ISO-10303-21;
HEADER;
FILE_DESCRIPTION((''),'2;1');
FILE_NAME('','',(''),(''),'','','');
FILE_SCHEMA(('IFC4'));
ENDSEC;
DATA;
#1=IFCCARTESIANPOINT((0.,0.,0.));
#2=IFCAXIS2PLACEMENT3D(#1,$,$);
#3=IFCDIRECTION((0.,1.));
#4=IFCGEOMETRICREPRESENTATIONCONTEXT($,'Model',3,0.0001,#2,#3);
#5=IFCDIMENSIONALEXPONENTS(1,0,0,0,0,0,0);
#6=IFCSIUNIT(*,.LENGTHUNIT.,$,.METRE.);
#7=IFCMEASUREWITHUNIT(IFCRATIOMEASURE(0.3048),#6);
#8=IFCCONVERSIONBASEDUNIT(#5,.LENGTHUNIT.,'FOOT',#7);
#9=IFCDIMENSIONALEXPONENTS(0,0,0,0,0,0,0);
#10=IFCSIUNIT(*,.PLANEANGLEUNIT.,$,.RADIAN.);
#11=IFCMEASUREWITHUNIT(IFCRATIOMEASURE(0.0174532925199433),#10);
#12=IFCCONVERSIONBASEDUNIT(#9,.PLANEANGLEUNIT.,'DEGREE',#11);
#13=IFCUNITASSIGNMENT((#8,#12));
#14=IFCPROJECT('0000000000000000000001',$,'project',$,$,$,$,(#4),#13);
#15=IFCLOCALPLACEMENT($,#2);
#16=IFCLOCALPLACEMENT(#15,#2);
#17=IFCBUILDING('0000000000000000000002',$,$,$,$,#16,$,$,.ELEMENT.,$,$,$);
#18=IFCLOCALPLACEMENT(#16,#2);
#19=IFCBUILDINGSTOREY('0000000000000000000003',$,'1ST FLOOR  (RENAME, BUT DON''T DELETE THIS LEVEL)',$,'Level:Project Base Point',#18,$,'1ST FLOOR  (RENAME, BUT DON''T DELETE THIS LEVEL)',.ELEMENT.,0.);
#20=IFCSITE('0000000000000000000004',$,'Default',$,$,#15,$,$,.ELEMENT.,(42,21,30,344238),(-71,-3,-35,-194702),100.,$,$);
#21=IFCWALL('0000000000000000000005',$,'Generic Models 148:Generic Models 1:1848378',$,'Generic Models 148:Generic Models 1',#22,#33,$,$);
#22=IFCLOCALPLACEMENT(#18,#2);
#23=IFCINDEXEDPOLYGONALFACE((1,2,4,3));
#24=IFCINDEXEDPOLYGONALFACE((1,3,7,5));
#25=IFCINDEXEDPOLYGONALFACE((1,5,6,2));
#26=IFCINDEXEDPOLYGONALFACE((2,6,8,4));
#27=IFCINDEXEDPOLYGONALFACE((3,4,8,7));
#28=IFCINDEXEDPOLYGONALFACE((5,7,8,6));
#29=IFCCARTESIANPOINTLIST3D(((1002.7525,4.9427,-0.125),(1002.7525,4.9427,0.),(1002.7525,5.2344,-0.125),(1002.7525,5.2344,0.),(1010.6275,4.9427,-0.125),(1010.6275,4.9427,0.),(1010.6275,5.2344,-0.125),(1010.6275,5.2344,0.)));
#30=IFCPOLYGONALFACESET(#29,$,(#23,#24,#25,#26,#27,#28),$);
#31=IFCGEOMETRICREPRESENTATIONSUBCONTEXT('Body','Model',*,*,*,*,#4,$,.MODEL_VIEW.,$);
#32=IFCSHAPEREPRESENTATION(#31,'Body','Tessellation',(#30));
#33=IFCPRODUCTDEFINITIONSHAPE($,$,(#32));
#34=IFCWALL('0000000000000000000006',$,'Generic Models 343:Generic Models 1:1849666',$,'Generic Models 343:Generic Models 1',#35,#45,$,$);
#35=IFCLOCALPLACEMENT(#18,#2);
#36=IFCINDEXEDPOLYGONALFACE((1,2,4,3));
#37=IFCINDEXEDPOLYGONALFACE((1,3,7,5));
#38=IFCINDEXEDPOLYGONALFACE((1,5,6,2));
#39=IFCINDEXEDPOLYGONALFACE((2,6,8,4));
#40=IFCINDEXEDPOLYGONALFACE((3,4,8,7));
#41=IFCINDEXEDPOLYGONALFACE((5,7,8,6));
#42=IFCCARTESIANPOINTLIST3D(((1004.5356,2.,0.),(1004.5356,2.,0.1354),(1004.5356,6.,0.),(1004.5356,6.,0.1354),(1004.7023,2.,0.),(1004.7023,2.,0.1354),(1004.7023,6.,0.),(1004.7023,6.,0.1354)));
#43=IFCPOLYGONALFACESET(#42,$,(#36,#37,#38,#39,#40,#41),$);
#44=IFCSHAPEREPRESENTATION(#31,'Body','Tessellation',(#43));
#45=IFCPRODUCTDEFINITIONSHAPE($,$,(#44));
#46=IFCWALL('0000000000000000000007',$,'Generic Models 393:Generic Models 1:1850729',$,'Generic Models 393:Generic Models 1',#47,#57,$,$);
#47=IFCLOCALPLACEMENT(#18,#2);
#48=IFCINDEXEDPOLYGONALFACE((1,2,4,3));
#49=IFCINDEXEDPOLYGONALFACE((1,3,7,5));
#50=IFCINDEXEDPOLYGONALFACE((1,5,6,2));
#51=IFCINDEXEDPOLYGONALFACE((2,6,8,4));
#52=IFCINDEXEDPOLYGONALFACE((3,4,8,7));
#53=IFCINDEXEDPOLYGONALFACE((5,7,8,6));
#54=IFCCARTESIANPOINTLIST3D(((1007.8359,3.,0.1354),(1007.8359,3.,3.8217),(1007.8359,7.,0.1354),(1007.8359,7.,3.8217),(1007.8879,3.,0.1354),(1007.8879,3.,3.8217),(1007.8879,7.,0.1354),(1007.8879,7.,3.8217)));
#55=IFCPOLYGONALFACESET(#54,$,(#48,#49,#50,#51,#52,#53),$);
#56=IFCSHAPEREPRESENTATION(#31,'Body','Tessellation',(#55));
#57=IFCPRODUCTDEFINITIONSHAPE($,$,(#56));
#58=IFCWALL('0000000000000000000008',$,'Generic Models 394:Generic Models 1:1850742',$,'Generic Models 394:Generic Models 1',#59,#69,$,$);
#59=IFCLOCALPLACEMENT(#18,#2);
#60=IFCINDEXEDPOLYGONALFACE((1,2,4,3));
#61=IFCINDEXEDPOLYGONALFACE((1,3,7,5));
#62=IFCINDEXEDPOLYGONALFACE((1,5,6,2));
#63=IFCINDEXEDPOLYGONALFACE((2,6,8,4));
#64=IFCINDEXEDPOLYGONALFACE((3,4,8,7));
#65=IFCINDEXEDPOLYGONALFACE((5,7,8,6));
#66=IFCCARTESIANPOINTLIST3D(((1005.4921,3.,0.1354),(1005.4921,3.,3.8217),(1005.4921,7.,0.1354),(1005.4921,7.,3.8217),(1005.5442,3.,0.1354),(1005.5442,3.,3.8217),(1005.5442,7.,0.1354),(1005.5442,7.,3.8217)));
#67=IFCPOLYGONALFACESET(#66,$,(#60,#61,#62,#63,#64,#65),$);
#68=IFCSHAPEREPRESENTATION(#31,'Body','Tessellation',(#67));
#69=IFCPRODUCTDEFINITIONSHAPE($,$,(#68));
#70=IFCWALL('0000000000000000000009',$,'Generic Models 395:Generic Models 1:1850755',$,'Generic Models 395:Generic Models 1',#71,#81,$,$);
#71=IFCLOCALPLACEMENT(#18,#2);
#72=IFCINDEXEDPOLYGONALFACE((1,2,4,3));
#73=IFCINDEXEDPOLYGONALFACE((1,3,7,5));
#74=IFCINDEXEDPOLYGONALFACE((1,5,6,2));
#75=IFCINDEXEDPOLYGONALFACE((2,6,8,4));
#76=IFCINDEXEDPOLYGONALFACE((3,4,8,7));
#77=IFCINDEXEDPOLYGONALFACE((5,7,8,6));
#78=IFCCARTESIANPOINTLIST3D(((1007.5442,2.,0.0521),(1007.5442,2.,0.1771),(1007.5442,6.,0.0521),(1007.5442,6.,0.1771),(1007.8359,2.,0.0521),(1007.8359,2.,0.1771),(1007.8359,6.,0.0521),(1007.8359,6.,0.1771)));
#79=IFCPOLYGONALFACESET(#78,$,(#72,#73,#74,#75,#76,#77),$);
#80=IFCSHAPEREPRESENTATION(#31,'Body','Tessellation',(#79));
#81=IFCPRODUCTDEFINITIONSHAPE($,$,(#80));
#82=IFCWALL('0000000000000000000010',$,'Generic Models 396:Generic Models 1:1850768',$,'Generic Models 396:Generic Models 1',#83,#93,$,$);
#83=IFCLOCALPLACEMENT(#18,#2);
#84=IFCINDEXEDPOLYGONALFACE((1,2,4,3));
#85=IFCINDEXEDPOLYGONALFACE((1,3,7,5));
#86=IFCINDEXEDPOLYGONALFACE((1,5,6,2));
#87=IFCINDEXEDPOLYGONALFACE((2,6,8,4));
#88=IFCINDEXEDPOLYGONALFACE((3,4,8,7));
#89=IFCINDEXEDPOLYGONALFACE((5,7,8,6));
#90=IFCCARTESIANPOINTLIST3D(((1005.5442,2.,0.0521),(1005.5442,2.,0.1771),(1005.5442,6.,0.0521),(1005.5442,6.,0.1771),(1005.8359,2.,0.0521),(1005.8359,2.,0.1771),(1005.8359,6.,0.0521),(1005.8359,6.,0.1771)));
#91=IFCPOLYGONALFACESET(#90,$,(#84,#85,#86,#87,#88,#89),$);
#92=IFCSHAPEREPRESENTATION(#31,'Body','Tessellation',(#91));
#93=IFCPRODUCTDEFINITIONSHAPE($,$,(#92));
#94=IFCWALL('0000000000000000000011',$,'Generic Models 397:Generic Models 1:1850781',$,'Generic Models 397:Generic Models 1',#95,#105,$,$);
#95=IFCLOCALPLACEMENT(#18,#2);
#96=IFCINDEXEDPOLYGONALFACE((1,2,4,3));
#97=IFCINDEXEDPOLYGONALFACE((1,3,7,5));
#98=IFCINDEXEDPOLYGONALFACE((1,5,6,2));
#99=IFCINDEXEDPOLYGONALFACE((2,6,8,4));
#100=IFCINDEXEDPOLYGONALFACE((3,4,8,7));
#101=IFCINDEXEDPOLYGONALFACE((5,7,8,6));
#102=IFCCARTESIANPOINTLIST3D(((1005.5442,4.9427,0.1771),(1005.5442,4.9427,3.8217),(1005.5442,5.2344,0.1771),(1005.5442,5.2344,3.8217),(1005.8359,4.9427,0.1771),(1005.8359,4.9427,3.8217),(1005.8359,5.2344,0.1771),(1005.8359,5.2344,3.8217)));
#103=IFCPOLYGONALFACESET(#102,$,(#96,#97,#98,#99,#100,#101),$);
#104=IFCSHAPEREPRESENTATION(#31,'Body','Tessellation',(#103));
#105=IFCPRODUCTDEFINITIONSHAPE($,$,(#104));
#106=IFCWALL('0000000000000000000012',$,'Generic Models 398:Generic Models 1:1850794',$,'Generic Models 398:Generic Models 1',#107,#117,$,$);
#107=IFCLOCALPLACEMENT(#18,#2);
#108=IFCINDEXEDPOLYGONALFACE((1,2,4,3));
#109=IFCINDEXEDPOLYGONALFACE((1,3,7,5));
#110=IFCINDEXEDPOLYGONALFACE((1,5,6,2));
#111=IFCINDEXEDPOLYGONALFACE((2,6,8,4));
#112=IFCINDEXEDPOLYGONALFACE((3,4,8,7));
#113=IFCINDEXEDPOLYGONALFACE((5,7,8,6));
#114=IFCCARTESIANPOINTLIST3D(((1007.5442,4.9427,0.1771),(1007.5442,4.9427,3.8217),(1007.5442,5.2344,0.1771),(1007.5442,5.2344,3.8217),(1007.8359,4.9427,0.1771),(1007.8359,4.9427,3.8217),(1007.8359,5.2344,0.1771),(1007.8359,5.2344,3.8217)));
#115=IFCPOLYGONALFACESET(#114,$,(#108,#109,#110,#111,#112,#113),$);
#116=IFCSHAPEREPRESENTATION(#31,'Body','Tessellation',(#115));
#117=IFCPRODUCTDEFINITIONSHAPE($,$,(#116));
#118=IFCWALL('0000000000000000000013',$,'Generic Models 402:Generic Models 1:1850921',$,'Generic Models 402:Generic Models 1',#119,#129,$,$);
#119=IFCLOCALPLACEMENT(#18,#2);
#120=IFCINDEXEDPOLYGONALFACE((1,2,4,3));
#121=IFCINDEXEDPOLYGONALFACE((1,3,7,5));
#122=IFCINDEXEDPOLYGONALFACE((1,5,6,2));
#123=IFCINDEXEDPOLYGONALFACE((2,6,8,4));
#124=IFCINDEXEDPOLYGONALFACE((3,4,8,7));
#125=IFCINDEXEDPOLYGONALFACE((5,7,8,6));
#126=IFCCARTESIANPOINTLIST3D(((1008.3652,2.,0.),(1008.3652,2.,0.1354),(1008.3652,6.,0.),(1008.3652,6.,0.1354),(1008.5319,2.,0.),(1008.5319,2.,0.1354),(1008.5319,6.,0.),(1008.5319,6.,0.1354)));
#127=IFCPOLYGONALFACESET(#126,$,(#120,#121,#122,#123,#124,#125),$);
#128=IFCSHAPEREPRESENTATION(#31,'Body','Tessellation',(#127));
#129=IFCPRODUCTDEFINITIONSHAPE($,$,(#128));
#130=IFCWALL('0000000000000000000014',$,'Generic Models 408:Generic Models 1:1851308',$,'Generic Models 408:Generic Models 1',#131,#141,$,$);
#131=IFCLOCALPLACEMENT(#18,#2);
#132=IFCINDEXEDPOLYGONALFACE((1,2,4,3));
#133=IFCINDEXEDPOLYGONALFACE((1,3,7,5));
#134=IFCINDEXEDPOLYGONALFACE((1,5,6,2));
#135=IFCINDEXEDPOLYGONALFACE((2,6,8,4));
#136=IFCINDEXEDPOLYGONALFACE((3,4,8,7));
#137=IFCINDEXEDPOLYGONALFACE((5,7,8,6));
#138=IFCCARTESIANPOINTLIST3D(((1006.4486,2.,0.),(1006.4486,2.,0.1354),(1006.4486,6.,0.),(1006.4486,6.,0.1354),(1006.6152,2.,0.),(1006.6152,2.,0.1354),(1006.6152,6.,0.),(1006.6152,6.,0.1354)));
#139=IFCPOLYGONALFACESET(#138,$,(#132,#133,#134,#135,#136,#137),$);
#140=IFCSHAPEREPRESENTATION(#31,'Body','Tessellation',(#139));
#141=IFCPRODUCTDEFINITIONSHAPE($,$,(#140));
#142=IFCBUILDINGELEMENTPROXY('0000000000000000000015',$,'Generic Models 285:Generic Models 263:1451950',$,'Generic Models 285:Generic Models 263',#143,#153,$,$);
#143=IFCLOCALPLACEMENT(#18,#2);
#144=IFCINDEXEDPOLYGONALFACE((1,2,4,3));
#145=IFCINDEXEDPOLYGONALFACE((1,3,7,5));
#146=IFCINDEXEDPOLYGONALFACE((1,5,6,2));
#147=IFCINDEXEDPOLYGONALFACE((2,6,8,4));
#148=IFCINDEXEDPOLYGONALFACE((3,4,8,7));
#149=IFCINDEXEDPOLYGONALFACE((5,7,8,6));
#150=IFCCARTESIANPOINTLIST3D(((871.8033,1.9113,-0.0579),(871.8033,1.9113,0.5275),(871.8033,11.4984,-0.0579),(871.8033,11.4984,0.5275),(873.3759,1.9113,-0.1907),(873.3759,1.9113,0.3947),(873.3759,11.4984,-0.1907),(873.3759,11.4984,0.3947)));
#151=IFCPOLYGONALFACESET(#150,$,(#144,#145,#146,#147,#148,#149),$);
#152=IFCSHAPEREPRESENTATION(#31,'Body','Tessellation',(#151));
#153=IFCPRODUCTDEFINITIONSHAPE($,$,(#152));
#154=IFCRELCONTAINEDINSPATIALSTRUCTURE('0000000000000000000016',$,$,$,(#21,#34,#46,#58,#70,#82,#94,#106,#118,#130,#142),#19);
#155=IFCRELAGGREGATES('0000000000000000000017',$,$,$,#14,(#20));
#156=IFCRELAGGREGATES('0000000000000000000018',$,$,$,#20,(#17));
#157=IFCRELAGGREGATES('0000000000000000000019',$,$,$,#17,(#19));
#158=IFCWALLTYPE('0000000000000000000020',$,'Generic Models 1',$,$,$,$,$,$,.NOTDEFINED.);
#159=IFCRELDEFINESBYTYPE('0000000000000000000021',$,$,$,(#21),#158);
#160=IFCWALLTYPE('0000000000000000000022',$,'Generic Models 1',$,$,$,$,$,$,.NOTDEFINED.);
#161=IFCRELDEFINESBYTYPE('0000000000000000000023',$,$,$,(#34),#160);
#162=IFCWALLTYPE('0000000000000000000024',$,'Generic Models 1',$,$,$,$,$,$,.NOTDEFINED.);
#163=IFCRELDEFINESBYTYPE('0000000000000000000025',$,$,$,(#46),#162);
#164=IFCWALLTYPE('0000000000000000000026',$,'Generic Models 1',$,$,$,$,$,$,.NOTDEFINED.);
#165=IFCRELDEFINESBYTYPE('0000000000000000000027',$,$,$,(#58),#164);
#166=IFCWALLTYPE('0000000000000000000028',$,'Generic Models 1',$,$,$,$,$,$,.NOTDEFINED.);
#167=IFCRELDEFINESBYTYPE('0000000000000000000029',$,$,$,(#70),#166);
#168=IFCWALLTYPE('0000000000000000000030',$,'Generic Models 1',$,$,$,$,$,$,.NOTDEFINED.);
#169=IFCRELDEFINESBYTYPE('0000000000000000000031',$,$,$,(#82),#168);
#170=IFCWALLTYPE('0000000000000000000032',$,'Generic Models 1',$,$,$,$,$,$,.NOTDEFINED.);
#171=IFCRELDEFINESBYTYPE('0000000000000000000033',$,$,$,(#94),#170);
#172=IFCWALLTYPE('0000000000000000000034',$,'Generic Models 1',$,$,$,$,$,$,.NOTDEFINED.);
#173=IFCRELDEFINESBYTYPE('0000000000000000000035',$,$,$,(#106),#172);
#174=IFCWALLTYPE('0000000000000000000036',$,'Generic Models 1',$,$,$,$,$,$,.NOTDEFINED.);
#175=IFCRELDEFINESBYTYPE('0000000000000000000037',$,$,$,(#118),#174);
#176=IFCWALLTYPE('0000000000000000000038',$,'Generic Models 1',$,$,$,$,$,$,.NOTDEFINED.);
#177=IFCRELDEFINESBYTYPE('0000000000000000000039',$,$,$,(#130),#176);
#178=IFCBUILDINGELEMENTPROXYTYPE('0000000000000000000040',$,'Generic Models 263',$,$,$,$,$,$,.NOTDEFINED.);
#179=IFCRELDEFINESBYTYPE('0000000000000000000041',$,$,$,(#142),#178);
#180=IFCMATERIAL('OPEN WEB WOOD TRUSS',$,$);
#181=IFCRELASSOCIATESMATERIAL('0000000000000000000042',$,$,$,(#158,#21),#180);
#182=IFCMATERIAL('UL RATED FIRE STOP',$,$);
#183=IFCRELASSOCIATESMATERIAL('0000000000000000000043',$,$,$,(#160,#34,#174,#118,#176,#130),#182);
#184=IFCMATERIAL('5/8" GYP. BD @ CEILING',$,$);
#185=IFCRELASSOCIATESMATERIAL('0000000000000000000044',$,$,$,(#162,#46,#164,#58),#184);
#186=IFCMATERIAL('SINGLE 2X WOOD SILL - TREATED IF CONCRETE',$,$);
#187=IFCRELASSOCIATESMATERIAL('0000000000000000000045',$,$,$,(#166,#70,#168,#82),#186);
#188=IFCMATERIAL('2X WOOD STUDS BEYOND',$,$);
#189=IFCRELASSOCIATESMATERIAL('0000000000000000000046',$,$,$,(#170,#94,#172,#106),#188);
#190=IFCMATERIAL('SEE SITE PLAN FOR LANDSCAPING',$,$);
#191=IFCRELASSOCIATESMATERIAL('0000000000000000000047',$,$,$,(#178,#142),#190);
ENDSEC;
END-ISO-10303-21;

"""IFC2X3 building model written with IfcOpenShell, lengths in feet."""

from ifc_helpers import new_model, entity, si_unit, converted_unit, direction, frame, frame_2d, origin, origin_2d_with_axis, place, context, subcontext, project, spatial, polyline, rectangle, outline, extrude, source, transform, mapped, material, type_object, type_shapes, element, save


model = new_model("IFC2X3")

# Units and contexts
model_context = context("Model", 3, precision=0.0001, world=origin(), true_north=direction((0.0, 1.0)))
body_context = subcontext(model_context, "Body", "Model", "MODEL_VIEW")
ifc_project = project(units=[converted_unit("LENGTHUNIT", "FOOT", entity("IfcRatioMeasure", 0.3048), si_unit("LENGTHUNIT", "METRE"), dimensions=[1, 0, 0, 0, 0, 0, 0]), converted_unit("PLANEANGLEUNIT", "DEGREE", entity("IfcRatioMeasure", 0.0174532925199433), si_unit("PLANEANGLEUNIT", "RADIAN"), dimensions=[0, 0, 0, 0, 0, 0, 0])], contexts=[model_context])

# Site, building, storey
site_placement = place(None, origin())
site = spatial("IfcSite", under=ifc_project, at=site_placement, Name="Default", CompositionType="ELEMENT", RefLatitude=(42, 21, 30, 344238), RefLongitude=(-71, -3, -35, -194702), RefElevation=100.0)
building_placement = place(site_placement, origin())
building = spatial("IfcBuilding", under=site, at=building_placement, CompositionType="ELEMENT")
storey_placement = place(building_placement, origin())
storey = spatial("IfcBuildingStorey", under=building, at=storey_placement, Name="1ST FLOOR  (RENAME, BUT DON'T DELETE THIS LEVEL)", ObjectType="Level:Project Base Point", LongName="1ST FLOOR  (RENAME, BUT DON'T DELETE THIS LEVEL)", CompositionType="ELEMENT", Elevation=0.0)

# Walls
ifc_material_1 = material(Name="OPEN WEB WOOD TRUSS")
wall_type_1 = type_object("IfcWallType", Name="Generic Models 1", PredefinedType="NOTDEFINED", material=ifc_material_1)
wall_1_placement = place(storey_placement, frame((1002.7525, 4.9427, -0.125)))
element("IfcWall", 1, at=wall_1_placement, inside=storey, type_object=wall_type_1, material=ifc_material_1, Name="Generic Models 148:Generic Models 1:1848378", ObjectType="Generic Models 148:Generic Models 1", context=body_context, shape_type="SweptSolid", body=[
    extrude(rectangle(XDim=0.2917, YDim=7.875, at=origin_2d_with_axis()), frame((3.9375, 0.1458, 0.0), z_axis=(0.0, 0.0, 1.0), x_axis=(0.0, 1.0, 0.0)), (0.0, 0.0, 1.0), 0.125),
])
ifc_material_2 = material(Name="UL RATED FIRE STOP")
wall_type_2 = type_object("IfcWallType", Name="Generic Models 1", PredefinedType="NOTDEFINED", material=ifc_material_2)
wall_2_placement = place(storey_placement, frame((1004.5356, 2.0, 0.0), z_axis=(0.0, 0.0, 1.0), x_axis=(0.0, 1.0, 0.0)))
element("IfcWall", 2, at=wall_2_placement, inside=storey, type_object=wall_type_2, material=ifc_material_2, Name="Generic Models 343:Generic Models 1:1849666", ObjectType="Generic Models 343:Generic Models 1", context=body_context, shape_type="SweptSolid", body=[
    extrude(rectangle(XDim=4.0, YDim=0.1667, at=frame_2d((0.0, 0.0), x_axis=(1.0, 0.0))), frame((2.0, -0.0833, 0.0)), (0.0, 0.0, 1.0), 0.1354),
])
ifc_material_3 = material(Name="5/8\" GYP. BD @ CEILING")
wall_type_3 = type_object("IfcWallType", Name="Generic Models 1", PredefinedType="NOTDEFINED", material=ifc_material_3)
wall_3_placement = place(storey_placement, frame((1007.8359, 3.0, 0.1354), z_axis=(0.0, 0.0, 1.0), x_axis=(0.0, 1.0, 0.0)))
element("IfcWall", 3, at=wall_3_placement, inside=storey, type_object=wall_type_3, material=ifc_material_3, Name="Generic Models 393:Generic Models 1:1850729", ObjectType="Generic Models 393:Generic Models 1", context=body_context, shape_type="SweptSolid", body=[
    extrude(rectangle(XDim=4.0, YDim=0.0521, at=frame_2d((0.0, 0.0), x_axis=(1.0, 0.0))), frame((2.0, -0.026, 0.0)), (0.0, 0.0, 1.0), 3.6863),
])
wall_type_4 = type_object("IfcWallType", Name="Generic Models 1", PredefinedType="NOTDEFINED", material=ifc_material_3)
wall_4_placement = place(storey_placement, frame((1005.4921, 3.0, 0.1354), z_axis=(0.0, 0.0, 1.0), x_axis=(0.0, 1.0, 0.0)))
element("IfcWall", 4, at=wall_4_placement, inside=storey, type_object=wall_type_4, material=ifc_material_3, Name="Generic Models 394:Generic Models 1:1850742", ObjectType="Generic Models 394:Generic Models 1", context=body_context, shape_type="SweptSolid", body=[
    extrude(rectangle(XDim=4.0, YDim=0.0521, at=frame_2d((0.0, 0.0), x_axis=(1.0, 0.0))), frame((2.0, -0.026, 0.0)), (0.0, 0.0, 1.0), 3.6863),
])
ifc_material_4 = material(Name="SINGLE 2X WOOD SILL - TREATED IF CONCRETE")
wall_type_5 = type_object("IfcWallType", Name="Generic Models 1", PredefinedType="NOTDEFINED", material=ifc_material_4)
wall_5_placement = place(storey_placement, frame((1007.5442, 2.0, 0.0521), z_axis=(0.0, 0.0, 1.0), x_axis=(0.0, 1.0, 0.0)))
element("IfcWall", 5, at=wall_5_placement, inside=storey, type_object=wall_type_5, material=ifc_material_4, Name="Generic Models 395:Generic Models 1:1850755", ObjectType="Generic Models 395:Generic Models 1", context=body_context, shape_type="SweptSolid", body=[
    extrude(rectangle(XDim=4.0, YDim=0.2917, at=frame_2d((0.0, 0.0), x_axis=(1.0, 0.0))), frame((2.0, -0.1458, 0.0)), (0.0, 0.0, 1.0), 0.125),
])
wall_type_6 = type_object("IfcWallType", Name="Generic Models 1", PredefinedType="NOTDEFINED", material=ifc_material_4)
wall_6_placement = place(storey_placement, frame((1005.5442, 2.0, 0.0521), z_axis=(0.0, 0.0, 1.0), x_axis=(0.0, 1.0, 0.0)))
element("IfcWall", 6, at=wall_6_placement, inside=storey, type_object=wall_type_6, material=ifc_material_4, Name="Generic Models 396:Generic Models 1:1850768", ObjectType="Generic Models 396:Generic Models 1", context=body_context, shape_type="SweptSolid", body=[
    extrude(rectangle(XDim=4.0, YDim=0.2917, at=frame_2d((0.0, 0.0), x_axis=(1.0, 0.0))), frame((2.0, -0.1458, 0.0)), (0.0, 0.0, 1.0), 0.125),
])
ifc_material_5 = material(Name="2X WOOD STUDS BEYOND")
wall_type_7 = type_object("IfcWallType", Name="Generic Models 1", PredefinedType="NOTDEFINED", material=ifc_material_5)
wall_7_placement = place(storey_placement, frame((1005.5442, 4.9427, 0.1771)))
element("IfcWall", 7, at=wall_7_placement, inside=storey, type_object=wall_type_7, material=ifc_material_5, Name="Generic Models 397:Generic Models 1:1850781", ObjectType="Generic Models 397:Generic Models 1", context=body_context, shape_type="SweptSolid", body=[
    extrude(rectangle(XDim=0.2917, YDim=0.2917, at=origin_2d_with_axis()), frame((0.1458, 0.1458, 0.0), z_axis=(0.0, 0.0, 1.0), x_axis=(0.0, 1.0, 0.0)), (0.0, 0.0, 1.0), 3.6447),
])
wall_type_8 = type_object("IfcWallType", Name="Generic Models 1", PredefinedType="NOTDEFINED", material=ifc_material_5)
wall_8_placement = place(storey_placement, frame((1007.5442, 4.9427, 0.1771)))
element("IfcWall", 8, at=wall_8_placement, inside=storey, type_object=wall_type_8, material=ifc_material_5, Name="Generic Models 398:Generic Models 1:1850794", ObjectType="Generic Models 398:Generic Models 1", context=body_context, shape_type="SweptSolid", body=[
    extrude(rectangle(XDim=0.2917, YDim=0.2917, at=origin_2d_with_axis()), frame((0.1458, 0.1458, 0.0), z_axis=(0.0, 0.0, 1.0), x_axis=(0.0, 1.0, 0.0)), (0.0, 0.0, 1.0), 3.6447),
])
wall_type_9 = type_object("IfcWallType", Name="Generic Models 1", PredefinedType="NOTDEFINED", material=ifc_material_2)
wall_9_placement = place(storey_placement, frame((1008.3652, 2.0, 0.0), z_axis=(0.0, 0.0, 1.0), x_axis=(0.0, 1.0, 0.0)))
element("IfcWall", 9, at=wall_9_placement, inside=storey, type_object=wall_type_9, material=ifc_material_2, Name="Generic Models 402:Generic Models 1:1850921", ObjectType="Generic Models 402:Generic Models 1", context=body_context, shape_type="SweptSolid", body=[
    extrude(rectangle(XDim=4.0, YDim=0.1667, at=frame_2d((0.0, 0.0), x_axis=(1.0, 0.0))), frame((2.0, -0.0833, 0.0)), (0.0, 0.0, 1.0), 0.1354),
])
wall_type_10 = type_object("IfcWallType", Name="Generic Models 1", PredefinedType="NOTDEFINED", material=ifc_material_2)
wall_10_placement = place(storey_placement, frame((1006.4486, 2.0, 0.0), z_axis=(0.0, 0.0, 1.0), x_axis=(0.0, 1.0, 0.0)))
element("IfcWall", 10, at=wall_10_placement, inside=storey, type_object=wall_type_10, material=ifc_material_2, Name="Generic Models 408:Generic Models 1:1851308", ObjectType="Generic Models 408:Generic Models 1", context=body_context, shape_type="SweptSolid", body=[
    extrude(rectangle(XDim=4.0, YDim=0.1667, at=origin_2d_with_axis()), frame((2.0, -0.0833, 0.0)), (0.0, 0.0, 1.0), 0.1354),
])

# Building element proxy
ifc_material_6 = material(Name="SEE SITE PLAN FOR LANDSCAPING")
building_element_proxy_type_1 = type_object("IfcBuildingElementProxyType", Name="Generic Models 263", PredefinedType="NOTDEFINED", material=ifc_material_6)
shared_shape_1 = source(origin(), body_context, "Body", "SweptSolid", [
    extrude(outline(polyline([(-0.8137, -0.2917), (0.7645, -0.2917), (0.8137, 0.2917), (-0.7645, 0.2917), (-0.8137, -0.2917)])), frame((0.7863, 0.0, 0.3591), z_axis=(0.0, 1.0, 0.0), x_axis=(-0.996456, 0.0, 0.08412)), (0.0, 0.0, 1.0), 9.5871),
])
type_shapes(building_element_proxy_type_1, [shared_shape_1])
proxy_1_placement = place(storey_placement, frame((871.8033, 1.9113, -0.1907)))
element("IfcBuildingElementProxy", 11, at=proxy_1_placement, inside=storey, type_object=building_element_proxy_type_1, material=ifc_material_6, Name="Generic Models 285:Generic Models 263:1451950", ObjectType="Generic Models 285:Generic Models 263", context=body_context, shape_type="MappedRepresentation", body=[
    mapped(shared_shape_1, transform((0.0, 0.0, 0.0), scale=1.0)),
])

save(model, "model.ifc")
